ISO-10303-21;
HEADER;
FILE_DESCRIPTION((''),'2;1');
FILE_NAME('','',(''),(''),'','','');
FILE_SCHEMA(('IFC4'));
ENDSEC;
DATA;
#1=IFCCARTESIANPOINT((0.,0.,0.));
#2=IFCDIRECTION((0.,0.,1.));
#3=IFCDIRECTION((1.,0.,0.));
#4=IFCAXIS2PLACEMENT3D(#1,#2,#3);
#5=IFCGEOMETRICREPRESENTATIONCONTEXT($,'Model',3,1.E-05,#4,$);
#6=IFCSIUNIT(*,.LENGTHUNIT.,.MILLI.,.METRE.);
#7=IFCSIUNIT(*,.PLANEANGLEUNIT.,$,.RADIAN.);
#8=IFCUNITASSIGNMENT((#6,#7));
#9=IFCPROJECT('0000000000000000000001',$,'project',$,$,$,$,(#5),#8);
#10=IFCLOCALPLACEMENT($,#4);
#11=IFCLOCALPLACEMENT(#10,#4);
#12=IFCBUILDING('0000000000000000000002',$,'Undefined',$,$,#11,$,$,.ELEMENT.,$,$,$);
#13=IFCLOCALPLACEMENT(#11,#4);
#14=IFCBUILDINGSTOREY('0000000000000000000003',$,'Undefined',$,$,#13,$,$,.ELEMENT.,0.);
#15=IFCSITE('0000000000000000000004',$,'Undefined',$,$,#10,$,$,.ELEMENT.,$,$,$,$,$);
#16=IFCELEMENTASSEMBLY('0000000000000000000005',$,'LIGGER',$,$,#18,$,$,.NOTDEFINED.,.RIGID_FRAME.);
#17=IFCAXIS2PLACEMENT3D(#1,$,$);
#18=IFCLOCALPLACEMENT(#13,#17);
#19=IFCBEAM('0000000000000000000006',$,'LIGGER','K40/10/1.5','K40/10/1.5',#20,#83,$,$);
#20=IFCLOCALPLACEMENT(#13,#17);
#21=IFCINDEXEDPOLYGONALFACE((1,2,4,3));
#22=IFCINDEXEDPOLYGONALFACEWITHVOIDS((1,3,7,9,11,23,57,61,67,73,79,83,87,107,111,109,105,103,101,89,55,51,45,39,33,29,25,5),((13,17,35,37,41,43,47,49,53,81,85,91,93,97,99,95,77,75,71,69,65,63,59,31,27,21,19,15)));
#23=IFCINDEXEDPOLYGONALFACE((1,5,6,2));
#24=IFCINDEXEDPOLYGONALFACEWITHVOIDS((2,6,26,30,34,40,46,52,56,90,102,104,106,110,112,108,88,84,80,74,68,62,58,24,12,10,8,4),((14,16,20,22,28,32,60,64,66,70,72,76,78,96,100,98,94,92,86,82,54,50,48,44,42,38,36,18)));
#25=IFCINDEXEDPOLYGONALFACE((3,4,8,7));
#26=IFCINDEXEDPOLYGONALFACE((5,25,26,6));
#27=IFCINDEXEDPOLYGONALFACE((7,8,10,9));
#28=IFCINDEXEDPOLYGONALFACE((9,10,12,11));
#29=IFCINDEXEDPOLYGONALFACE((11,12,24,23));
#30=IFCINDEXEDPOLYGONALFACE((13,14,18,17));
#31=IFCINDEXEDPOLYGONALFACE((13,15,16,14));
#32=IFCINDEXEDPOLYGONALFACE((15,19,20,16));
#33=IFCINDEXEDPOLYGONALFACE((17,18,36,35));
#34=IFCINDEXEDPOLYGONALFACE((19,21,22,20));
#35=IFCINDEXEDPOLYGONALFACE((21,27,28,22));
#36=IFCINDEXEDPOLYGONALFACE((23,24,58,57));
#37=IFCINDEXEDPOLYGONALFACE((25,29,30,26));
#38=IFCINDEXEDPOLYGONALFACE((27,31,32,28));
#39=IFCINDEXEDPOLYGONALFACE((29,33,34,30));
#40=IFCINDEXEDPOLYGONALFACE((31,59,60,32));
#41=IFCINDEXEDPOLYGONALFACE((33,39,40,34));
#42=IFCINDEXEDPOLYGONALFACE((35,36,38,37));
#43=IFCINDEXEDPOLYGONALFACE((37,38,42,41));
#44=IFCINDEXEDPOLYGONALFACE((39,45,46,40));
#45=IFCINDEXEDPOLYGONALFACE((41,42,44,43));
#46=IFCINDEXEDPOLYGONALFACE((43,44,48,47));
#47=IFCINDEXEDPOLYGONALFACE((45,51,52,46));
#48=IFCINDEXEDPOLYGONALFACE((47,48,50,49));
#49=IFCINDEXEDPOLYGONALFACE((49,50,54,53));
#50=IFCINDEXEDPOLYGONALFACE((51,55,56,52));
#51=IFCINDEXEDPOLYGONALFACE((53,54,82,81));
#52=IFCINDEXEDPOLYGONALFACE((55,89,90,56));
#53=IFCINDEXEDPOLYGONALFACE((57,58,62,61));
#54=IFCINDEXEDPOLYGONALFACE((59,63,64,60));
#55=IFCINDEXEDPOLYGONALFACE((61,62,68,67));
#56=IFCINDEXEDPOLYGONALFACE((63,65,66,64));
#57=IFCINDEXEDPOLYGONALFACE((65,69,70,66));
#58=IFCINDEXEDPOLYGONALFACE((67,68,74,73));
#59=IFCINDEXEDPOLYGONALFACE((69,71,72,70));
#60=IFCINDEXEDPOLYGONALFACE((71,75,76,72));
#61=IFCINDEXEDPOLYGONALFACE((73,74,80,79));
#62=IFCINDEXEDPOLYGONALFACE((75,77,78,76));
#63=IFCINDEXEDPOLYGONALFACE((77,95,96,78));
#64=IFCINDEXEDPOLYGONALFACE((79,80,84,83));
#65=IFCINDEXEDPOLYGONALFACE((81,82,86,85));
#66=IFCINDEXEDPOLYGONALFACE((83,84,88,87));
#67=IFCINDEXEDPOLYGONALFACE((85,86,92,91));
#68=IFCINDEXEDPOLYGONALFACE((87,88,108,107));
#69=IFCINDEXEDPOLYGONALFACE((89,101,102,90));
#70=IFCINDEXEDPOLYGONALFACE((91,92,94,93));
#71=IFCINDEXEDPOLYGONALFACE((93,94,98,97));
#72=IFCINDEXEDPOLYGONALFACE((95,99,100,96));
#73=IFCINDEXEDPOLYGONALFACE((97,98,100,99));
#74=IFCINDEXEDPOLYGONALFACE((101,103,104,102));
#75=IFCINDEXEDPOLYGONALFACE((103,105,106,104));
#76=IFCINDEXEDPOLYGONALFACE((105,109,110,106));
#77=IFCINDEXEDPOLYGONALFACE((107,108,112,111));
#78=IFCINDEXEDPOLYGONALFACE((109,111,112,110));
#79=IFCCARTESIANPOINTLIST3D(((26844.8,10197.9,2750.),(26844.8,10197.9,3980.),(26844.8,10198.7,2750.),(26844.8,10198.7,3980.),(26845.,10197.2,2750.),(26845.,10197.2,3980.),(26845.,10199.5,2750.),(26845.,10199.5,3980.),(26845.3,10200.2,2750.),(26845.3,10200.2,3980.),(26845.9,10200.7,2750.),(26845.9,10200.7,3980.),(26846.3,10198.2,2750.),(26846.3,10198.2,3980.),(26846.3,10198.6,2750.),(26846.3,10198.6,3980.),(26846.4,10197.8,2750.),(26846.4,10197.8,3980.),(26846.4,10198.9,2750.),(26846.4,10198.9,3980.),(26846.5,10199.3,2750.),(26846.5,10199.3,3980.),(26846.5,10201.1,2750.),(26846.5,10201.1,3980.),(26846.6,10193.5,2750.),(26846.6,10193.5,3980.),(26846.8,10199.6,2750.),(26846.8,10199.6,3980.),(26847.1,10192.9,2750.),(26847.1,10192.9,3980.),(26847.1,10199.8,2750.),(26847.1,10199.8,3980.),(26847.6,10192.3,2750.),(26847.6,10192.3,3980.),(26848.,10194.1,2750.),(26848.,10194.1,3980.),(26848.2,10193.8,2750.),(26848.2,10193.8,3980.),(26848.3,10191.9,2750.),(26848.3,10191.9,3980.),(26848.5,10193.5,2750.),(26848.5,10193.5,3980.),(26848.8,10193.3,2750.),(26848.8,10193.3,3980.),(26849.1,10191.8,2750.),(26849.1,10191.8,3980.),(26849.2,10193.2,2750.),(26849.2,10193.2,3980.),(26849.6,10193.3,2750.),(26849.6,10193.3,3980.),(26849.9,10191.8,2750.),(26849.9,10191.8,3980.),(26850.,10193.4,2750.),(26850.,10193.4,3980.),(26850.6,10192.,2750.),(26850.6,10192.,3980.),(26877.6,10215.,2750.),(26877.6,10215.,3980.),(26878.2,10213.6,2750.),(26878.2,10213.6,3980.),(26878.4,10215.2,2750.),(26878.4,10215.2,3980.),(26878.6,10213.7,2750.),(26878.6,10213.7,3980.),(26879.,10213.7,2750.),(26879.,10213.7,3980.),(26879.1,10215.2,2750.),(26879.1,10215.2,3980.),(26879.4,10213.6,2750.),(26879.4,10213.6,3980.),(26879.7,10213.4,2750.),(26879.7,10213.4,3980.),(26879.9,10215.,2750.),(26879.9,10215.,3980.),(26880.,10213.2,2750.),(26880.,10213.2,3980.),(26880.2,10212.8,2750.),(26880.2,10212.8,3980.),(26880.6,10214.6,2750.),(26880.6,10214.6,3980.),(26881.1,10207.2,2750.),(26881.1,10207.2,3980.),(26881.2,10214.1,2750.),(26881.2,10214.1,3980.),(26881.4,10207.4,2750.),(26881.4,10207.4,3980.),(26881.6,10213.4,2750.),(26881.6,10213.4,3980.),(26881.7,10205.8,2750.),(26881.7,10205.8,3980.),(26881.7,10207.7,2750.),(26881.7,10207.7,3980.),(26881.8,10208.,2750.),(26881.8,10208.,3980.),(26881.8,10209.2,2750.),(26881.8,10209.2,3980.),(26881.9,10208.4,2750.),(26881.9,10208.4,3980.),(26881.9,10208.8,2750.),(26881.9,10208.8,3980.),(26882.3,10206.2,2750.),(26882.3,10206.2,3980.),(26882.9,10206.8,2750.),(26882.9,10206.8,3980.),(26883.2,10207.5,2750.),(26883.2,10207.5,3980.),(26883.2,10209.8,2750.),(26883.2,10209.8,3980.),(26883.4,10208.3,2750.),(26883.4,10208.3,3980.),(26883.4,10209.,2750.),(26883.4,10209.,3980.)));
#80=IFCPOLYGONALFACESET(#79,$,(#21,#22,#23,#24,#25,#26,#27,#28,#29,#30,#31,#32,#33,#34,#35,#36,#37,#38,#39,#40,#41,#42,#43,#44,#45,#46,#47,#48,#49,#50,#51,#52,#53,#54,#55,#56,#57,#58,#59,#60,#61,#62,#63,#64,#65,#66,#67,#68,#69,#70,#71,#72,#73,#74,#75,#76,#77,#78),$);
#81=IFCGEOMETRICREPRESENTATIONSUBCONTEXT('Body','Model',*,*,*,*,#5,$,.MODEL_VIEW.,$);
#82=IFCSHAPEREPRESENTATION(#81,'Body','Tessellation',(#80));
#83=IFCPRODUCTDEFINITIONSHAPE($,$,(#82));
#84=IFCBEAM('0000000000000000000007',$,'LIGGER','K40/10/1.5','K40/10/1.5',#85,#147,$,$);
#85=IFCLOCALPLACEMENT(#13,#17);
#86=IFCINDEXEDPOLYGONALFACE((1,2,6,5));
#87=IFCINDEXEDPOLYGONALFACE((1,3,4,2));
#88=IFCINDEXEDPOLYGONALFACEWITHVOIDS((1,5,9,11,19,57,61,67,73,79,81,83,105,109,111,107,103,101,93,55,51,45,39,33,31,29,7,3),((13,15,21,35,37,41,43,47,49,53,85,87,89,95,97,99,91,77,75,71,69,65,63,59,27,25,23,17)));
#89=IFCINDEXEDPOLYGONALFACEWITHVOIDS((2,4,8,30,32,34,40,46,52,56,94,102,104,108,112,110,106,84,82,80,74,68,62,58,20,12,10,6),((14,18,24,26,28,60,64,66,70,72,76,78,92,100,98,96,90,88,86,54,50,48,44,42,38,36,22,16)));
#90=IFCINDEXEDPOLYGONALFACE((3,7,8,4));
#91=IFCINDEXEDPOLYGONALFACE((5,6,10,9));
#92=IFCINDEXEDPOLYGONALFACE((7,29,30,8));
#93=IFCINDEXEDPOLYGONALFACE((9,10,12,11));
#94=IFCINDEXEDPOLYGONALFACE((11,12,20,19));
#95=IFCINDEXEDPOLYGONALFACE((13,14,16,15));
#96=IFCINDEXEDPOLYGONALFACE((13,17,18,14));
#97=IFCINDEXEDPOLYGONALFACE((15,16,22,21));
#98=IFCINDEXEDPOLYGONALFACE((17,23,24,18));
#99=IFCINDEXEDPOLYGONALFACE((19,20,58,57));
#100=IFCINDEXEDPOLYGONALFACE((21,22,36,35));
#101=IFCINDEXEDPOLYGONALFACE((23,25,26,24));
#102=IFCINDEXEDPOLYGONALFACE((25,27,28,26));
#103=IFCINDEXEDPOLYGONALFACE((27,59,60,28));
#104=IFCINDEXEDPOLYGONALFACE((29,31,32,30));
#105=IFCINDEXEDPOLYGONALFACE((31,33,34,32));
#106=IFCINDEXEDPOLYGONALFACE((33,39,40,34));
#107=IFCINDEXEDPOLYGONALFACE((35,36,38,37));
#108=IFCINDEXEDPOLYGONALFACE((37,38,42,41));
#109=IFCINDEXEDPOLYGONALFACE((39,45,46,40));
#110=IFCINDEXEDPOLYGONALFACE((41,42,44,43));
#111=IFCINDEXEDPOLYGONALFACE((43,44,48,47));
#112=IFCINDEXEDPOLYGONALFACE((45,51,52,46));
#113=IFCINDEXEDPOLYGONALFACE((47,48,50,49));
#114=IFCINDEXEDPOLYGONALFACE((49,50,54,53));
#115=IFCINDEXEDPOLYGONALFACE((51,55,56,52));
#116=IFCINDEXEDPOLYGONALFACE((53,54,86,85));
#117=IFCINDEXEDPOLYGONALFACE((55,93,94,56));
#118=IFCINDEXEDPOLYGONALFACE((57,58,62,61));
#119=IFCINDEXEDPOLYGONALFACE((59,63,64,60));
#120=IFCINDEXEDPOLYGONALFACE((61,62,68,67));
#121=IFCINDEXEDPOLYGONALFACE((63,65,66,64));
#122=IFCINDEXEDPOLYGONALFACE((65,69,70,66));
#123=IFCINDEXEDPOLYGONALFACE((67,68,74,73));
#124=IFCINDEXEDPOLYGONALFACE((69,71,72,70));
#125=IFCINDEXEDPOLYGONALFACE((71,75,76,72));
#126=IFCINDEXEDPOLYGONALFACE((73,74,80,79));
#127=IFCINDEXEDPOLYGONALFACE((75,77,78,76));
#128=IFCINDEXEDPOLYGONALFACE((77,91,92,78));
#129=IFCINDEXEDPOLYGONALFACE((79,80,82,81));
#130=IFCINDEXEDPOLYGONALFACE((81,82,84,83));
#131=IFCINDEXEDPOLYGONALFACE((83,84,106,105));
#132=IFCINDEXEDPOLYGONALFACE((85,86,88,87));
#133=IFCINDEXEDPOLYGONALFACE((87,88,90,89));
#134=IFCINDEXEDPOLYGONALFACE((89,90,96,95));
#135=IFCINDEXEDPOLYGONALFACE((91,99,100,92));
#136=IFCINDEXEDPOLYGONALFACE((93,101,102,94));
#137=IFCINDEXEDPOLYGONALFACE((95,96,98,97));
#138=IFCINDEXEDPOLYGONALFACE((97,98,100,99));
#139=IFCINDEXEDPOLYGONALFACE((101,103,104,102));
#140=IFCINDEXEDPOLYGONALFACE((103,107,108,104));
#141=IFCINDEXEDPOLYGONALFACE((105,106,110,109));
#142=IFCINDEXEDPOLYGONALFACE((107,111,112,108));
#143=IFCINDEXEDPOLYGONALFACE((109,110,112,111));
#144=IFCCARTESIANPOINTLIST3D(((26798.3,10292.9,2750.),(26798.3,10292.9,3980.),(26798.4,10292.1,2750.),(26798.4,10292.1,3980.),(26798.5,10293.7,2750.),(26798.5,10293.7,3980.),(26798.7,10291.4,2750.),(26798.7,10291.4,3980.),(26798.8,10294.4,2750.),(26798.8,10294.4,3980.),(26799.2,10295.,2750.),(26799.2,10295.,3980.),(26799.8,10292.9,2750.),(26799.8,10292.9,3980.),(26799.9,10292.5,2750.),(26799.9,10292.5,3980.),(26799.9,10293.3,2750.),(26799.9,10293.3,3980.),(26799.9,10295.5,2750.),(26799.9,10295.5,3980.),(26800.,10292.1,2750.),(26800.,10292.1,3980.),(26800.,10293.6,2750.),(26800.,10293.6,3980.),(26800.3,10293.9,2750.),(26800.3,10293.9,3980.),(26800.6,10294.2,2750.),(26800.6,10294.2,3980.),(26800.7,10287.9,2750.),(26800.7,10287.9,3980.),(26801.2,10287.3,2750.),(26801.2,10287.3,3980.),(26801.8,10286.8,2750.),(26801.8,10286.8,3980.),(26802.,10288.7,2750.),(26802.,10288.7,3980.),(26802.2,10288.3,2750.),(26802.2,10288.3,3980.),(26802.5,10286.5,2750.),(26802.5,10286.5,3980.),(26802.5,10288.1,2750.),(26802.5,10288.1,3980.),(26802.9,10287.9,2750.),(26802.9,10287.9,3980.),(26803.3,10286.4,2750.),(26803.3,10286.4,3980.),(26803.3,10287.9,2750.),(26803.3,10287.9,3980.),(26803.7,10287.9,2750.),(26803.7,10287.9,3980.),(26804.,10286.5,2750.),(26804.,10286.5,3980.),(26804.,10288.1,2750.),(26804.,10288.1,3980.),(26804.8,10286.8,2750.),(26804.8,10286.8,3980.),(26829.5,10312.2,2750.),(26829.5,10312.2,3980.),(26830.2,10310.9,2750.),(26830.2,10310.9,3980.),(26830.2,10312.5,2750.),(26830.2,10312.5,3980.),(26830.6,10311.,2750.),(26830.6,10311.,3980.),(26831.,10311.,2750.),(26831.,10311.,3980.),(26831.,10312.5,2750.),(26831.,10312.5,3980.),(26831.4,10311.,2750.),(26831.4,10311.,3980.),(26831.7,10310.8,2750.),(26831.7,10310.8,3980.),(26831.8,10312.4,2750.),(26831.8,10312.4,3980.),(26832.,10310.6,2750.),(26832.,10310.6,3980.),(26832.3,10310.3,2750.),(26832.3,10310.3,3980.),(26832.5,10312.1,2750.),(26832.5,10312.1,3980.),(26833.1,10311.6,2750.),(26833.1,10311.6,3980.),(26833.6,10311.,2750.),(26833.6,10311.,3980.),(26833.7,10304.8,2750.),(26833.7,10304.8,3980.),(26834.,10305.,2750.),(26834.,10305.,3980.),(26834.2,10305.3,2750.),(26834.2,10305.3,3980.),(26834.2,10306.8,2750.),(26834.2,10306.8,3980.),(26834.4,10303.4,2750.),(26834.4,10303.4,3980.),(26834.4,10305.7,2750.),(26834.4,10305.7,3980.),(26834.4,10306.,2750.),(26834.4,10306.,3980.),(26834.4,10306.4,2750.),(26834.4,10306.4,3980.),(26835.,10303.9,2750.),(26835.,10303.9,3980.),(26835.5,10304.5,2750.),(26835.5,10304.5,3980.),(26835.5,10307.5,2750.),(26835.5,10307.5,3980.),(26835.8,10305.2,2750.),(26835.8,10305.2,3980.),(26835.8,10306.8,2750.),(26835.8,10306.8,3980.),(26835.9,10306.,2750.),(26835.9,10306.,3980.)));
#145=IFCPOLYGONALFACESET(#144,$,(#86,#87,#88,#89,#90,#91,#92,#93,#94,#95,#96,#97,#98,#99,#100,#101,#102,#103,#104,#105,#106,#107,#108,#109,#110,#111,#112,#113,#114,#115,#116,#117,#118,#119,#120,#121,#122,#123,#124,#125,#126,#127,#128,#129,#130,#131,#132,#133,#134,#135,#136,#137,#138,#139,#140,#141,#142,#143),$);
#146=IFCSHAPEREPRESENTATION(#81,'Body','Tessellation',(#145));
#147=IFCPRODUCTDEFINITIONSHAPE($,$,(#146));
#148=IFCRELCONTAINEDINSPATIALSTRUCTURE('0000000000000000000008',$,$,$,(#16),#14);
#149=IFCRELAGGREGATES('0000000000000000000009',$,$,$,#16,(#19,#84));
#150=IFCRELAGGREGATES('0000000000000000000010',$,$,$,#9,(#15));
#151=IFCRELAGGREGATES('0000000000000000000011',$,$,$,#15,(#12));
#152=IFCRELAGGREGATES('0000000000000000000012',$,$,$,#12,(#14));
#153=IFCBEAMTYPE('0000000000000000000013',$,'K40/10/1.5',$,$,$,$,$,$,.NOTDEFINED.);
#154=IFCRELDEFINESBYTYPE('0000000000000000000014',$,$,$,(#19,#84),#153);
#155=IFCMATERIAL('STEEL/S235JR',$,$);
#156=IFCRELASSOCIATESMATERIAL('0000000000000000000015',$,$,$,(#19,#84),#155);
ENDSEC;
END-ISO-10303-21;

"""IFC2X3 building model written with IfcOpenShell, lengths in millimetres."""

from ifc_helpers import new_model, si_unit, frame, origin_with_axes, origin_2d_with_axis, place, context, subcontext, project, spatial, hollow_rectangle, extrude, material, type_object, element, aggregate, save


model = new_model("IFC2X3")

# Units and contexts
model_context = context("Model", 3, precision=1e-05, world=origin_with_axes())
body_context = subcontext(model_context, "Body", "Model", "MODEL_VIEW")
ifc_project = project(units=[si_unit("LENGTHUNIT", "METRE", prefix="MILLI"), si_unit("PLANEANGLEUNIT", "RADIAN")], contexts=[model_context])

# Site, building, storey
site_placement = place(None, origin_with_axes())
site = spatial("IfcSite", under=ifc_project, at=site_placement, Name="Undefined", CompositionType="ELEMENT")
building_placement = place(site_placement, origin_with_axes())
building = spatial("IfcBuilding", under=site, at=building_placement, Name="Undefined", CompositionType="ELEMENT")
storey_placement = place(building_placement, origin_with_axes())
storey = spatial("IfcBuildingStorey", under=building, at=storey_placement, Name="Undefined", CompositionType="ELEMENT", Elevation=0.0)

# Element assembly, beam
ifc_material_1 = material(Name="STEEL/S235JR")
assembly_1_placement = place(storey_placement, origin_with_axes())
assembly_1 = element("IfcElementAssembly", 1, at=assembly_1_placement, inside=storey, Name="LIGGER", AssemblyPlace="NOTDEFINED", PredefinedType="RIGID_FRAME")
beam_type_1 = type_object("IfcBeamType", Name="K40/10/1.5", PredefinedType="NOTDEFINED")
beam_1_placement = place(assembly_1_placement, frame((26864.1, 10203.5, 3980.0), z_axis=(0.913609, 0.406594, 0.0), x_axis=(0.0, 0.0, -1.0)))
beam_1 = element("IfcBeam", 2, at=beam_1_placement, type_object=beam_type_1, material=ifc_material_1, Name="LIGGER", Description="K40/10/1.5", ObjectType="K40/10/1.5", context=body_context, shape_type="SweptSolid", body=[
    extrude(hollow_rectangle(XDim=10.0, YDim=40.0, WallThickness=1.5, InnerFilletRadius=1.5, OuterFilletRadius=3.0, at=origin_2d_with_axis()), frame((1230.0, 0.0, 0.0), z_axis=(-1.0, 0.0, 0.0), x_axis=(0.0, -1.0, 0.0)), (0.0, 0.0, 1.0), 1230.0),
])

# Beam
beam_2_placement = place(assembly_1_placement, frame((26817.1, 10299.5, 3980.0), z_axis=(0.871568, 0.490275, 0.0), x_axis=(0.0, 0.0, -1.0)))
beam_2 = element("IfcBeam", 3, at=beam_2_placement, type_object=beam_type_1, material=ifc_material_1, Name="LIGGER", Description="K40/10/1.5", ObjectType="K40/10/1.5", context=body_context, shape_type="SweptSolid", body=[
    extrude(hollow_rectangle(XDim=10.0, YDim=40.0, WallThickness=1.5, InnerFilletRadius=1.5, OuterFilletRadius=3.0, at=origin_2d_with_axis()), frame((1230.0, 0.0, 0.0), z_axis=(-1.0, 0.0, 0.0), x_axis=(0.0, -1.0, 0.0)), (0.0, 0.0, 1.0), 1230.0),
])

aggregate(assembly_1, [beam_1, beam_2])

save(model, "model.ifc")
